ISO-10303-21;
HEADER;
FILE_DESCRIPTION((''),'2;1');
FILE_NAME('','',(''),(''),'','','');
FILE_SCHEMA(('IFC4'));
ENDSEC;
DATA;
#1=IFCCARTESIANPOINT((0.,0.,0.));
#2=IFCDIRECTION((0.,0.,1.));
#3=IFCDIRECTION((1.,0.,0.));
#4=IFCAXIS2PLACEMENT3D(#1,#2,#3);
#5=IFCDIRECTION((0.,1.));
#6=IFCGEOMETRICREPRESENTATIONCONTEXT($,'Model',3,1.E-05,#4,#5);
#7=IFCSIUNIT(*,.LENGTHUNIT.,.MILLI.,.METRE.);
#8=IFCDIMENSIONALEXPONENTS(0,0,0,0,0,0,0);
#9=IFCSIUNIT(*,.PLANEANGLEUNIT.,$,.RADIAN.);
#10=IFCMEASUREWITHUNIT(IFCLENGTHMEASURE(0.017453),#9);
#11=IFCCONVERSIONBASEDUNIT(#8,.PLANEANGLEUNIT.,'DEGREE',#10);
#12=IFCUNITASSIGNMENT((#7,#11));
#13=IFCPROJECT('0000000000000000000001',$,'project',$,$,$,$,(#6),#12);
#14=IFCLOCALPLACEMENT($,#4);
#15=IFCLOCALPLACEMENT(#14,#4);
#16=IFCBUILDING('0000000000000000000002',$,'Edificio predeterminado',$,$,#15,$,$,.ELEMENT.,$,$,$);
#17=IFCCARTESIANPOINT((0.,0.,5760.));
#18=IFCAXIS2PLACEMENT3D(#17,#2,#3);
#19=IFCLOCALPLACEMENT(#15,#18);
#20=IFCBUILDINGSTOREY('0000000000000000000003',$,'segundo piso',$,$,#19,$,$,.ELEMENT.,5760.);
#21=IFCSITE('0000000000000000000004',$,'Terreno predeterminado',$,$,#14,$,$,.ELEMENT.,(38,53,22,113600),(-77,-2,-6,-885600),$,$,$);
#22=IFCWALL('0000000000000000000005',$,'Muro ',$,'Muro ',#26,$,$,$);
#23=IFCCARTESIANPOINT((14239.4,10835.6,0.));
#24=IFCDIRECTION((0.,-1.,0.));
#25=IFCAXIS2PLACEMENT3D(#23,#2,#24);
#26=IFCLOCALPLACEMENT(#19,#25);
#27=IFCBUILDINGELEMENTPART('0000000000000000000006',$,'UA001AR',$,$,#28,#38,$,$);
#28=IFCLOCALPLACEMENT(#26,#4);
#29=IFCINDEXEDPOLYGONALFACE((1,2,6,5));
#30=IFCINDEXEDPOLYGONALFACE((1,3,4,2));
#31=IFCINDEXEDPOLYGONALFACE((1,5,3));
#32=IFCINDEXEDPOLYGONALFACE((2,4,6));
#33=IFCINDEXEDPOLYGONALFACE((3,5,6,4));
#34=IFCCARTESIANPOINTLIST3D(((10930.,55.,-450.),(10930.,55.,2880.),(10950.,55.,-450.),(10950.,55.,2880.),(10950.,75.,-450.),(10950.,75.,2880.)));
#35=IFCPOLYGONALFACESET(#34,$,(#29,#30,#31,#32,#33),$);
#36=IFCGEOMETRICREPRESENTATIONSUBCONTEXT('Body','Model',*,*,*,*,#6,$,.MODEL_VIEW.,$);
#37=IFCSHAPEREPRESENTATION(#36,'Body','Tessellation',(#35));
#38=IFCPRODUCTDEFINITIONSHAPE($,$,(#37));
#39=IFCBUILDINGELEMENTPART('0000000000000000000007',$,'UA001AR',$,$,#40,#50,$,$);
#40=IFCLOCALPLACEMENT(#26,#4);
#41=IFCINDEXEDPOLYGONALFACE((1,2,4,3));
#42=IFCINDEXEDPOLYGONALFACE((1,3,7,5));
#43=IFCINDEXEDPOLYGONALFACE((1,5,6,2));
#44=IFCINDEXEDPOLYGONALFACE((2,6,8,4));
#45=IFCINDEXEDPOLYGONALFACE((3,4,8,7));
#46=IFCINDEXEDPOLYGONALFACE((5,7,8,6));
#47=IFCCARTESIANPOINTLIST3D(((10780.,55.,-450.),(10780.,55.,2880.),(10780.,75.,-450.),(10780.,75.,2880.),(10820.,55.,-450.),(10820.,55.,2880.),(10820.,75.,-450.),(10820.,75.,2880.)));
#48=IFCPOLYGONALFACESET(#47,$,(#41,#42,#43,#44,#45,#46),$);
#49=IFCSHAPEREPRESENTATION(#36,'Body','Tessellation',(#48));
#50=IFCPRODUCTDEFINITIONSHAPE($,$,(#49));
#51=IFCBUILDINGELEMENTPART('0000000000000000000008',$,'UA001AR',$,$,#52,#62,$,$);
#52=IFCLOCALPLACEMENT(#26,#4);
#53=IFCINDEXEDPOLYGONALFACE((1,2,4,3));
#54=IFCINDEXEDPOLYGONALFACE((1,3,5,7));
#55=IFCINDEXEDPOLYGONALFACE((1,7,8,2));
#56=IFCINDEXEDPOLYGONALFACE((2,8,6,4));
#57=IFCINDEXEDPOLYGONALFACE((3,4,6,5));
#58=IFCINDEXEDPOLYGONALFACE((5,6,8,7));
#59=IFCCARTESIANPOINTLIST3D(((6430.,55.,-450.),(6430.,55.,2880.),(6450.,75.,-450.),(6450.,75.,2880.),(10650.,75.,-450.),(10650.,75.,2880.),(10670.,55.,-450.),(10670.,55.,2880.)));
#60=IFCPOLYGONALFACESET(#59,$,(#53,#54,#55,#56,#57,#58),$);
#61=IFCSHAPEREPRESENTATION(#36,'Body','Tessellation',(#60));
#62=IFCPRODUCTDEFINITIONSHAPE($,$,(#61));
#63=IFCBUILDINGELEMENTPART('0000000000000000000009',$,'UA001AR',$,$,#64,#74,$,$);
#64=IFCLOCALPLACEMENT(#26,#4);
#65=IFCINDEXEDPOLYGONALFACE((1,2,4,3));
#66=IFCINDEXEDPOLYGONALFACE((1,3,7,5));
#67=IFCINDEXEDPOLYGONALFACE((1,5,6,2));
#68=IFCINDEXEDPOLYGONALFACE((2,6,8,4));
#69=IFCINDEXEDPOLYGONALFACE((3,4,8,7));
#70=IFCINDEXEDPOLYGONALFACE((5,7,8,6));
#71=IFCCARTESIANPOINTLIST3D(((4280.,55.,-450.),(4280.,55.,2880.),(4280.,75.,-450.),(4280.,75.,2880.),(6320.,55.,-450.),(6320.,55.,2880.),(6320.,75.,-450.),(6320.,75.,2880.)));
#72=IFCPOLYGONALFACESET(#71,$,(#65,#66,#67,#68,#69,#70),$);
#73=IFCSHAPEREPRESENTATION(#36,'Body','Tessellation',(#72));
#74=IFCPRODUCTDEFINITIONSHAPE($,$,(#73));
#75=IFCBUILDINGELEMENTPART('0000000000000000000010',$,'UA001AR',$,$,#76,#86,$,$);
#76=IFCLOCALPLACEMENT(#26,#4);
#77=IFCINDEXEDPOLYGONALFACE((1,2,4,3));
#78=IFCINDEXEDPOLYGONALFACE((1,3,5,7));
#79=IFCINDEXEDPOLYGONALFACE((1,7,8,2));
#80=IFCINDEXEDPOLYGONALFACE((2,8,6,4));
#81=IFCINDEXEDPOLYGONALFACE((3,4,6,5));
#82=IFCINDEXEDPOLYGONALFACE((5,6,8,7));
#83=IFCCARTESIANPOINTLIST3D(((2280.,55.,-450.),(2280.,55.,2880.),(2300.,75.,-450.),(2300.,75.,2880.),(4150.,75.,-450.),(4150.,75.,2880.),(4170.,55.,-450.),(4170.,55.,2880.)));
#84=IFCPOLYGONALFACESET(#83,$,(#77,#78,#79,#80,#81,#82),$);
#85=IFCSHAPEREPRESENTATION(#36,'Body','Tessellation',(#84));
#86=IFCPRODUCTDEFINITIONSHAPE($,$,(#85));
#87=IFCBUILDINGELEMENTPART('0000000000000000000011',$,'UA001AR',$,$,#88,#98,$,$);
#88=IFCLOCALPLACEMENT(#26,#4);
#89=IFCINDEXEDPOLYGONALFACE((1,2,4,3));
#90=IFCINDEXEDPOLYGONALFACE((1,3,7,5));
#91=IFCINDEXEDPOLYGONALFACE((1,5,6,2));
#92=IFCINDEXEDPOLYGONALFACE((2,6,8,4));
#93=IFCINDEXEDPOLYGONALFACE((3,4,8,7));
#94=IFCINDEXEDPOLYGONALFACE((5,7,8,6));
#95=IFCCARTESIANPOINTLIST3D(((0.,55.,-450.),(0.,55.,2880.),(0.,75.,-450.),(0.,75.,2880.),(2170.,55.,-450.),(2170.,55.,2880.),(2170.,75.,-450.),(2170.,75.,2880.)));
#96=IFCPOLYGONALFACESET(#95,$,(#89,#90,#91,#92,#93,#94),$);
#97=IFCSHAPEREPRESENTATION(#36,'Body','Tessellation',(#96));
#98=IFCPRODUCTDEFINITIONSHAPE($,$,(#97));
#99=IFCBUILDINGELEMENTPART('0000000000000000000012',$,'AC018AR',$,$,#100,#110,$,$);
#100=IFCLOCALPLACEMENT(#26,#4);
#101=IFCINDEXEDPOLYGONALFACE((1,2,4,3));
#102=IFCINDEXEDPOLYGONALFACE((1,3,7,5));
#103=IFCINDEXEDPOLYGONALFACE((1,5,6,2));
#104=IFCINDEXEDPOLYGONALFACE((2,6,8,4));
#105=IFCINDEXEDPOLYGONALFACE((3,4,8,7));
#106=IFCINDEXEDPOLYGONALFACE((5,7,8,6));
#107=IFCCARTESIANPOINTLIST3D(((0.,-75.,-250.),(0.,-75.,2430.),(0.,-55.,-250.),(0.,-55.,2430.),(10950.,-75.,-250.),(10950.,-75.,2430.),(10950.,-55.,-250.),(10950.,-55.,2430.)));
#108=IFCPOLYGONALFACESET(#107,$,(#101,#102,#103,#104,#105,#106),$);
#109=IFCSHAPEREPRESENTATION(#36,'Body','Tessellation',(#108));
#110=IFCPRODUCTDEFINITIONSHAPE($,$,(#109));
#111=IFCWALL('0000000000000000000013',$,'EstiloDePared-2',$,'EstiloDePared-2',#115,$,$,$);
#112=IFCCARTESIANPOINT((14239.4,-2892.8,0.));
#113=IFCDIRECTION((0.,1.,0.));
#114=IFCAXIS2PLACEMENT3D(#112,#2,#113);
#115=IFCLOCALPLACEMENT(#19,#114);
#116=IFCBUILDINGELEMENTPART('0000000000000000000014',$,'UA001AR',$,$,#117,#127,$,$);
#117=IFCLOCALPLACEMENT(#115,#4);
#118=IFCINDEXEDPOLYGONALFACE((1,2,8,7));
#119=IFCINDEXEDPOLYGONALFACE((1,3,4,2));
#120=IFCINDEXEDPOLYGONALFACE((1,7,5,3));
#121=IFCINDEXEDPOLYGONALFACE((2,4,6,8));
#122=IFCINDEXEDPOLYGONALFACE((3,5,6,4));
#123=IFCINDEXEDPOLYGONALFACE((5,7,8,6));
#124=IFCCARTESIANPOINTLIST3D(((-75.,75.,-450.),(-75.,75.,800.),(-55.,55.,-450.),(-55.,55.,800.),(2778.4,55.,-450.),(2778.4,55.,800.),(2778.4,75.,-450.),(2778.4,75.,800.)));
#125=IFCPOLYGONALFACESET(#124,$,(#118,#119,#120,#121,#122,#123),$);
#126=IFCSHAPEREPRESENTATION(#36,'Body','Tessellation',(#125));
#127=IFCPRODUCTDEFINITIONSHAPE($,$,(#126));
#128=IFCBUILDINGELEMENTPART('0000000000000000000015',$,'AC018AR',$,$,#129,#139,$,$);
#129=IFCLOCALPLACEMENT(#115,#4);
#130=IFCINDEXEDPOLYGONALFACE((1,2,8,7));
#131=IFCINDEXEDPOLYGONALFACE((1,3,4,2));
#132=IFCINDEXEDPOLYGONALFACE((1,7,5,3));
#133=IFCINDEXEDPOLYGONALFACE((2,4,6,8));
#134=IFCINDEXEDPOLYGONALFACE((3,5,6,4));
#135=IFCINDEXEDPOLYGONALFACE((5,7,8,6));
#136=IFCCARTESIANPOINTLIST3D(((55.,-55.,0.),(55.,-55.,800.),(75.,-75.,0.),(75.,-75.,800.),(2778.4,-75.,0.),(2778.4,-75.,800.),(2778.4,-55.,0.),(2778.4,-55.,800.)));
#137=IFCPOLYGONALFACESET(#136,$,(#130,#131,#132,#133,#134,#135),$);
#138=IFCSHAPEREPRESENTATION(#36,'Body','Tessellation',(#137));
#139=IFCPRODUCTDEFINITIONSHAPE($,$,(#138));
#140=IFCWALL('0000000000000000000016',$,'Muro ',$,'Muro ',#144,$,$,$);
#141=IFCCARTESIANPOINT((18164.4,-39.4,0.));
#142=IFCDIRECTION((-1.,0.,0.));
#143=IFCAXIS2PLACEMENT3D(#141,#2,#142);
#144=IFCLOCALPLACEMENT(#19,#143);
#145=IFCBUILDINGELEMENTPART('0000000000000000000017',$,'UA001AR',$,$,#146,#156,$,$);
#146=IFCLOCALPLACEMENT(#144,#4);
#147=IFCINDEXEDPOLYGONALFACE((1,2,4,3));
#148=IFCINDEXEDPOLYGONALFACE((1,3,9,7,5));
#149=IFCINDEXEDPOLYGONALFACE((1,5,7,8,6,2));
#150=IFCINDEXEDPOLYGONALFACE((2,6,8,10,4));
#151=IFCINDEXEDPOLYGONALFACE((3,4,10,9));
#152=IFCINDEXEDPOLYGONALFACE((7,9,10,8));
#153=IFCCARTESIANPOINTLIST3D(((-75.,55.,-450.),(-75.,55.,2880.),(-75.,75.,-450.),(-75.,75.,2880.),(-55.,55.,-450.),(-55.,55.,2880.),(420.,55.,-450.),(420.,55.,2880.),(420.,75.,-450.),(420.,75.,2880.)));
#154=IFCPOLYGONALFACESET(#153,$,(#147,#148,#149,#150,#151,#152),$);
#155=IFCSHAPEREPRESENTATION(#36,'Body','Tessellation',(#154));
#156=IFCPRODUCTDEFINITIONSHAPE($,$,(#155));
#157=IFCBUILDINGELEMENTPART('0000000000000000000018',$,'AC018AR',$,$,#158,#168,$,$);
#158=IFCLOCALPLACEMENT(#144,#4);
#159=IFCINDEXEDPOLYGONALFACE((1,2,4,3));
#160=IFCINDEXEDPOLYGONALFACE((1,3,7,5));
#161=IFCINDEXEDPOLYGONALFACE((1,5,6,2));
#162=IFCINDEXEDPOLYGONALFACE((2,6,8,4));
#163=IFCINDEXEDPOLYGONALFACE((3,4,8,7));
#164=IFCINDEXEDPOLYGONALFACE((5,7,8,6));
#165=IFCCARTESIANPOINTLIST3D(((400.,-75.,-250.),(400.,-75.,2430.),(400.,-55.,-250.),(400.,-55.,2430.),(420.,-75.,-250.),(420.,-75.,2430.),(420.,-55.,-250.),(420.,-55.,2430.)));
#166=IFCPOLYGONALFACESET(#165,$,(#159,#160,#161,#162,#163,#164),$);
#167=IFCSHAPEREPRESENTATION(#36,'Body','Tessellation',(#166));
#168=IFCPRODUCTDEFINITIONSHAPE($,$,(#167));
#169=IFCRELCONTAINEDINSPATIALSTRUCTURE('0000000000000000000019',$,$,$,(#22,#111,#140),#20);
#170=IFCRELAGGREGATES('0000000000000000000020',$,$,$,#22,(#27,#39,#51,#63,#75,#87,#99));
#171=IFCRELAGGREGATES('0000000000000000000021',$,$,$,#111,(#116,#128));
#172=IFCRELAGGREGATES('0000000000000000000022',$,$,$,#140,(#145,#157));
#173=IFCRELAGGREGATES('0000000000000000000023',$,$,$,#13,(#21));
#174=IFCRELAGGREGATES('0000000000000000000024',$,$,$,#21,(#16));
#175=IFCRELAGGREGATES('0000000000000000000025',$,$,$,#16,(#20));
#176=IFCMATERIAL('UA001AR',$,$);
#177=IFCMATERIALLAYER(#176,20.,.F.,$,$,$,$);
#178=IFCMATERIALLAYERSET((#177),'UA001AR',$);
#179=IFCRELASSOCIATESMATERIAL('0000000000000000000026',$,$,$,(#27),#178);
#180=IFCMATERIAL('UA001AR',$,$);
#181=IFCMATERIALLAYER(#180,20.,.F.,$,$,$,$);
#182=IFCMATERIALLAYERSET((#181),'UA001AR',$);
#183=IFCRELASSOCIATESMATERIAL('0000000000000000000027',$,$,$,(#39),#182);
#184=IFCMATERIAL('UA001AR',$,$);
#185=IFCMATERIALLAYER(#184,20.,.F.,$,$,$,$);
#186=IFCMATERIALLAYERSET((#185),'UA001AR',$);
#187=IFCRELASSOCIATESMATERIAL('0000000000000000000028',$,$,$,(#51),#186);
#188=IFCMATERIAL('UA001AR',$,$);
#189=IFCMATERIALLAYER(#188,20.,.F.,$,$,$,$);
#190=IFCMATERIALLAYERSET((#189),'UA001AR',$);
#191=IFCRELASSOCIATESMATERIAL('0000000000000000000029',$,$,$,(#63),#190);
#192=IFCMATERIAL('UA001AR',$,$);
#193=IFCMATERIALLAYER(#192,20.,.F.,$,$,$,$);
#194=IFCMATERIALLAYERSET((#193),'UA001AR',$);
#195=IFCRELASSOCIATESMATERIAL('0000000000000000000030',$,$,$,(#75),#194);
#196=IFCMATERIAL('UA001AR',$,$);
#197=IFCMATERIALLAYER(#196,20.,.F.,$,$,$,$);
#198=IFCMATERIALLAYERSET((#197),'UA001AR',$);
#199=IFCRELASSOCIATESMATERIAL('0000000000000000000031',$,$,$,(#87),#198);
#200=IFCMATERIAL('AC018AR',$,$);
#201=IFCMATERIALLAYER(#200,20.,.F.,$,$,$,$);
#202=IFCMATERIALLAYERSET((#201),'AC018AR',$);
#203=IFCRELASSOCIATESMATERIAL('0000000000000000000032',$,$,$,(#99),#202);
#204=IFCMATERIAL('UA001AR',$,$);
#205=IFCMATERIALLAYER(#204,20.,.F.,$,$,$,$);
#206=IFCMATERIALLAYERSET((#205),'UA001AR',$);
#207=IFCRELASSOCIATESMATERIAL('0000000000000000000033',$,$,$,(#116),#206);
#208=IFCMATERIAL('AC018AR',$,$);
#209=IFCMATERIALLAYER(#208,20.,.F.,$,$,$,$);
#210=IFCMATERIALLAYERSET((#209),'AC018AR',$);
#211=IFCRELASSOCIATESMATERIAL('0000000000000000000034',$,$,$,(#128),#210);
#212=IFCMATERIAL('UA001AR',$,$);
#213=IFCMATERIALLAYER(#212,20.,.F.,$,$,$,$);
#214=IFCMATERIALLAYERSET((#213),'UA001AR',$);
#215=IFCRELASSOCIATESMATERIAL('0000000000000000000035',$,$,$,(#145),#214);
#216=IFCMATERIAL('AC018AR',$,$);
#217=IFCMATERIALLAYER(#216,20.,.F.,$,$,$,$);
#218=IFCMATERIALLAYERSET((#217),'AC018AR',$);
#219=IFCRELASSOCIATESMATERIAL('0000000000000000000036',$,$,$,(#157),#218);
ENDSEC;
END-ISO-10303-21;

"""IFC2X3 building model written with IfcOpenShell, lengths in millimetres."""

from ifc_helpers import new_model, entity, si_unit, converted_unit, direction, frame, origin_with_axes, place, context, subcontext, project, spatial, polyline, outline, extrude, material, layer, layer_set, layer_usage, element, aggregate, save


model = new_model("IFC2X3")

# Units and contexts
model_context = context("Model", 3, precision=1e-05, world=origin_with_axes(), true_north=direction((0.0, 1.0)))
body_context = subcontext(model_context, "Body", "Model", "MODEL_VIEW")
ifc_project = project(units=[si_unit("LENGTHUNIT", "METRE", prefix="MILLI"), converted_unit("PLANEANGLEUNIT", "DEGREE", entity("IfcLengthMeasure", 0.017453), si_unit("PLANEANGLEUNIT", "RADIAN"), dimensions=[0, 0, 0, 0, 0, 0, 0])], contexts=[model_context])

# Site, building, storey
site_placement = place(None, origin_with_axes())
site = spatial("IfcSite", under=ifc_project, at=site_placement, Name="Terreno predeterminado", CompositionType="ELEMENT", RefLatitude=(38, 53, 22, 113600), RefLongitude=(-77, -2, -6, -885600))
building_placement = place(site_placement, origin_with_axes())
building = spatial("IfcBuilding", under=site, at=building_placement, Name="Edificio predeterminado", CompositionType="ELEMENT")
storey_placement = place(building_placement, frame((0.0, 0.0, 5760.0), z_axis=(0.0, 0.0, 1.0), x_axis=(1.0, 0.0, 0.0)))
storey = spatial("IfcBuildingStorey", under=building, at=storey_placement, Name="segundo piso", CompositionType="ELEMENT", Elevation=5760.0)

# Walls, building element parts
wall_1_placement = place(storey_placement, frame((14239.4, 10835.6, 0.0), z_axis=(0.0, 0.0, 1.0), x_axis=(0.0, -1.0, 0.0)))
wall_1 = element("IfcWall", 1, at=wall_1_placement, inside=storey, Name="Muro ", ObjectType="Muro ")
ifc_material_1 = material(Name="UA001AR")
ifc_layer_1 = layer(ifc_material_1, 20.0, ventilated=False)
ifc_layer_set_1 = layer_set([ifc_layer_1], Name="UA001AR")
ifc_layer_usage_1 = layer_usage(ifc_layer_set_1, "AXIS2", "NEGATIVE", -75.0)
building_element_part_1_placement = place(wall_1_placement, origin_with_axes())
building_element_part_1 = element("IfcBuildingElementPart", 2, at=building_element_part_1_placement, material=ifc_layer_usage_1, Name="UA001AR", context=body_context, shape_type="SweptSolid", body=[
    extrude(outline(polyline([(10950.0, 75.0), (10950.0, 55.0), (10930.0, 55.0), (10950.0, 75.0)])), frame((0.0, 0.0, -450.0), z_axis=(0.0, 0.0, 1.0), x_axis=(1.0, 0.0, 0.0)), (0.0, 0.0, 1.0), 3330.0),
])
ifc_material_2 = material(Name="UA001AR")
ifc_layer_2 = layer(ifc_material_2, 20.0, ventilated=False)
ifc_layer_set_2 = layer_set([ifc_layer_2], Name="UA001AR")
ifc_layer_usage_2 = layer_usage(ifc_layer_set_2, "AXIS2", "NEGATIVE", -75.0)
building_element_part_2_placement = place(wall_1_placement, origin_with_axes())
building_element_part_2 = element("IfcBuildingElementPart", 3, at=building_element_part_2_placement, material=ifc_layer_usage_2, Name="UA001AR", context=body_context, shape_type="SweptSolid", body=[
    extrude(outline(polyline([(10820.0, 75.0), (10820.0, 55.0), (10780.0, 55.0), (10780.0, 75.0), (10820.0, 75.0)])), frame((0.0, 0.0, -450.0), z_axis=(0.0, 0.0, 1.0), x_axis=(1.0, 0.0, 0.0)), (0.0, 0.0, 1.0), 3330.0),
])
ifc_material_3 = material(Name="UA001AR")
ifc_layer_3 = layer(ifc_material_3, 20.0, ventilated=False)
ifc_layer_set_3 = layer_set([ifc_layer_3], Name="UA001AR")
ifc_layer_usage_3 = layer_usage(ifc_layer_set_3, "AXIS2", "NEGATIVE", -75.0)
building_element_part_3_placement = place(wall_1_placement, origin_with_axes())
building_element_part_3 = element("IfcBuildingElementPart", 4, at=building_element_part_3_placement, material=ifc_layer_usage_3, Name="UA001AR", context=body_context, shape_type="SweptSolid", body=[
    extrude(outline(polyline([(10650.0, 75.0), (10670.0, 55.0), (6430.0, 55.0), (6450.0, 75.0), (10650.0, 75.0)])), frame((0.0, 0.0, -450.0), z_axis=(0.0, 0.0, 1.0), x_axis=(1.0, 0.0, 0.0)), (0.0, 0.0, 1.0), 3330.0),
])
ifc_material_4 = material(Name="UA001AR")
ifc_layer_4 = layer(ifc_material_4, 20.0, ventilated=False)
ifc_layer_set_4 = layer_set([ifc_layer_4], Name="UA001AR")
ifc_layer_usage_4 = layer_usage(ifc_layer_set_4, "AXIS2", "NEGATIVE", -75.0)
building_element_part_4_placement = place(wall_1_placement, origin_with_axes())
building_element_part_4 = element("IfcBuildingElementPart", 5, at=building_element_part_4_placement, material=ifc_layer_usage_4, Name="UA001AR", context=body_context, shape_type="SweptSolid", body=[
    extrude(outline(polyline([(4280.0, 75.0), (6320.0, 75.0), (6320.0, 55.0), (4280.0, 55.0), (4280.0, 75.0)])), frame((0.0, 0.0, -450.0), z_axis=(0.0, 0.0, 1.0), x_axis=(1.0, 0.0, 0.0)), (0.0, 0.0, 1.0), 3330.0),
])
ifc_material_5 = material(Name="UA001AR")
ifc_layer_5 = layer(ifc_material_5, 20.0, ventilated=False)
ifc_layer_set_5 = layer_set([ifc_layer_5], Name="UA001AR")
ifc_layer_usage_5 = layer_usage(ifc_layer_set_5, "AXIS2", "NEGATIVE", -75.0)
building_element_part_5_placement = place(wall_1_placement, origin_with_axes())
building_element_part_5 = element("IfcBuildingElementPart", 6, at=building_element_part_5_placement, material=ifc_layer_usage_5, Name="UA001AR", context=body_context, shape_type="SweptSolid", body=[
    extrude(outline(polyline([(4150.0, 75.0), (4170.0, 55.0), (2280.0, 55.0), (2300.0, 75.0), (4150.0, 75.0)])), frame((0.0, 0.0, -450.0), z_axis=(0.0, 0.0, 1.0), x_axis=(1.0, 0.0, 0.0)), (0.0, 0.0, 1.0), 3330.0),
])
ifc_material_6 = material(Name="UA001AR")
ifc_layer_6 = layer(ifc_material_6, 20.0, ventilated=False)
ifc_layer_set_6 = layer_set([ifc_layer_6], Name="UA001AR")
ifc_layer_usage_6 = layer_usage(ifc_layer_set_6, "AXIS2", "NEGATIVE", -75.0)
building_element_part_6_placement = place(wall_1_placement, origin_with_axes())
building_element_part_6 = element("IfcBuildingElementPart", 7, at=building_element_part_6_placement, material=ifc_layer_usage_6, Name="UA001AR", context=body_context, shape_type="SweptSolid", body=[
    extrude(outline(polyline([(2170.0, 75.0), (2170.0, 55.0), (0.0, 55.0), (0.0, 75.0), (2170.0, 75.0)])), frame((0.0, 0.0, -450.0), z_axis=(0.0, 0.0, 1.0), x_axis=(1.0, 0.0, 0.0)), (0.0, 0.0, 1.0), 3330.0),
])
ifc_material_7 = material(Name="AC018AR")
ifc_layer_7 = layer(ifc_material_7, 20.0, ventilated=False)
ifc_layer_set_7 = layer_set([ifc_layer_7], Name="AC018AR")
ifc_layer_usage_7 = layer_usage(ifc_layer_set_7, "AXIS2", "NEGATIVE", 55.0)
building_element_part_7_placement = place(wall_1_placement, origin_with_axes())
building_element_part_7 = element("IfcBuildingElementPart", 8, at=building_element_part_7_placement, material=ifc_layer_usage_7, Name="AC018AR", context=body_context, shape_type="SweptSolid", body=[
    extrude(outline(polyline([(10950.0, -55.0), (10950.0, -75.0), (0.0, -75.0), (0.0, -55.0), (10950.0, -55.0)])), frame((0.0, 0.0, -250.0), z_axis=(0.0, 0.0, 1.0), x_axis=(1.0, 0.0, 0.0)), (0.0, 0.0, 1.0), 2680.0),
])
aggregate(wall_1, [building_element_part_1, building_element_part_2, building_element_part_3, building_element_part_4, building_element_part_5, building_element_part_6, building_element_part_7])
wall_2_placement = place(storey_placement, frame((14239.4, -2892.8, 0.0), z_axis=(0.0, 0.0, 1.0), x_axis=(0.0, 1.0, 0.0)))
wall_2 = element("IfcWall", 9, at=wall_2_placement, inside=storey, Name="EstiloDePared-2", ObjectType="EstiloDePared-2")
ifc_material_8 = material(Name="UA001AR")
ifc_layer_8 = layer(ifc_material_8, 20.0, ventilated=False)
ifc_layer_set_8 = layer_set([ifc_layer_8], Name="UA001AR")
ifc_layer_usage_8 = layer_usage(ifc_layer_set_8, "AXIS2", "NEGATIVE", -75.0)
building_element_part_8_placement = place(wall_2_placement, origin_with_axes())
building_element_part_8 = element("IfcBuildingElementPart", 10, at=building_element_part_8_placement, material=ifc_layer_usage_8, Name="UA001AR", context=body_context, shape_type="SweptSolid", body=[
    extrude(outline(polyline([(2778.4, 75.0), (2778.4, 55.0), (-55.0, 55.0), (-75.0, 75.0), (2778.4, 75.0)])), frame((0.0, 0.0, -450.0), z_axis=(0.0, 0.0, 1.0), x_axis=(1.0, 0.0, 0.0)), (0.0, 0.0, 1.0), 1250.0),
])
ifc_material_9 = material(Name="AC018AR")
ifc_layer_9 = layer(ifc_material_9, 20.0, ventilated=False)
ifc_layer_set_9 = layer_set([ifc_layer_9], Name="AC018AR")
ifc_layer_usage_9 = layer_usage(ifc_layer_set_9, "AXIS2", "NEGATIVE", 55.0)
building_element_part_9_placement = place(wall_2_placement, origin_with_axes())
building_element_part_9 = element("IfcBuildingElementPart", 11, at=building_element_part_9_placement, material=ifc_layer_usage_9, Name="AC018AR", context=body_context, shape_type="SweptSolid", body=[
    extrude(outline(polyline([(2778.4, -55.0), (2778.4, -75.0), (75.0, -75.0), (55.0, -55.0), (2778.4, -55.0)])), origin_with_axes(), (0.0, 0.0, 1.0), 800.0),
])
aggregate(wall_2, [building_element_part_8, building_element_part_9])
wall_3_placement = place(storey_placement, frame((18164.4, -39.4, 0.0), z_axis=(0.0, 0.0, 1.0), x_axis=(-1.0, 0.0, 0.0)))
wall_3 = element("IfcWall", 12, at=wall_3_placement, inside=storey, Name="Muro ", ObjectType="Muro ")
ifc_material_10 = material(Name="UA001AR")
ifc_layer_10 = layer(ifc_material_10, 20.0, ventilated=False)
ifc_layer_set_10 = layer_set([ifc_layer_10], Name="UA001AR")
ifc_layer_usage_10 = layer_usage(ifc_layer_set_10, "AXIS2", "NEGATIVE", -75.0)
building_element_part_10_placement = place(wall_3_placement, origin_with_axes())
building_element_part_10 = element("IfcBuildingElementPart", 13, at=building_element_part_10_placement, material=ifc_layer_usage_10, Name="UA001AR", context=body_context, shape_type="SweptSolid", body=[
    extrude(outline(polyline([(420.0, 75.0), (420.0, 55.0), (-55.0, 55.0), (-75.0, 55.0), (-75.0, 75.0), (420.0, 75.0)])), frame((0.0, 0.0, -450.0), z_axis=(0.0, 0.0, 1.0), x_axis=(1.0, 0.0, 0.0)), (0.0, 0.0, 1.0), 3330.0),
])
ifc_material_11 = material(Name="AC018AR")
ifc_layer_11 = layer(ifc_material_11, 20.0, ventilated=False)
ifc_layer_set_11 = layer_set([ifc_layer_11], Name="AC018AR")
ifc_layer_usage_11 = layer_usage(ifc_layer_set_11, "AXIS2", "NEGATIVE", 55.0)
building_element_part_11_placement = place(wall_3_placement, origin_with_axes())
building_element_part_11 = element("IfcBuildingElementPart", 14, at=building_element_part_11_placement, material=ifc_layer_usage_11, Name="AC018AR", context=body_context, shape_type="SweptSolid", body=[
    extrude(outline(polyline([(420.0, -55.0), (420.0, -75.0), (400.0, -75.0), (400.0, -55.0), (420.0, -55.0)])), frame((0.0, 0.0, -250.0), z_axis=(0.0, 0.0, 1.0), x_axis=(1.0, 0.0, 0.0)), (0.0, 0.0, 1.0), 2680.0),
])
aggregate(wall_3, [building_element_part_10, building_element_part_11])

save(model, "model.ifc")
